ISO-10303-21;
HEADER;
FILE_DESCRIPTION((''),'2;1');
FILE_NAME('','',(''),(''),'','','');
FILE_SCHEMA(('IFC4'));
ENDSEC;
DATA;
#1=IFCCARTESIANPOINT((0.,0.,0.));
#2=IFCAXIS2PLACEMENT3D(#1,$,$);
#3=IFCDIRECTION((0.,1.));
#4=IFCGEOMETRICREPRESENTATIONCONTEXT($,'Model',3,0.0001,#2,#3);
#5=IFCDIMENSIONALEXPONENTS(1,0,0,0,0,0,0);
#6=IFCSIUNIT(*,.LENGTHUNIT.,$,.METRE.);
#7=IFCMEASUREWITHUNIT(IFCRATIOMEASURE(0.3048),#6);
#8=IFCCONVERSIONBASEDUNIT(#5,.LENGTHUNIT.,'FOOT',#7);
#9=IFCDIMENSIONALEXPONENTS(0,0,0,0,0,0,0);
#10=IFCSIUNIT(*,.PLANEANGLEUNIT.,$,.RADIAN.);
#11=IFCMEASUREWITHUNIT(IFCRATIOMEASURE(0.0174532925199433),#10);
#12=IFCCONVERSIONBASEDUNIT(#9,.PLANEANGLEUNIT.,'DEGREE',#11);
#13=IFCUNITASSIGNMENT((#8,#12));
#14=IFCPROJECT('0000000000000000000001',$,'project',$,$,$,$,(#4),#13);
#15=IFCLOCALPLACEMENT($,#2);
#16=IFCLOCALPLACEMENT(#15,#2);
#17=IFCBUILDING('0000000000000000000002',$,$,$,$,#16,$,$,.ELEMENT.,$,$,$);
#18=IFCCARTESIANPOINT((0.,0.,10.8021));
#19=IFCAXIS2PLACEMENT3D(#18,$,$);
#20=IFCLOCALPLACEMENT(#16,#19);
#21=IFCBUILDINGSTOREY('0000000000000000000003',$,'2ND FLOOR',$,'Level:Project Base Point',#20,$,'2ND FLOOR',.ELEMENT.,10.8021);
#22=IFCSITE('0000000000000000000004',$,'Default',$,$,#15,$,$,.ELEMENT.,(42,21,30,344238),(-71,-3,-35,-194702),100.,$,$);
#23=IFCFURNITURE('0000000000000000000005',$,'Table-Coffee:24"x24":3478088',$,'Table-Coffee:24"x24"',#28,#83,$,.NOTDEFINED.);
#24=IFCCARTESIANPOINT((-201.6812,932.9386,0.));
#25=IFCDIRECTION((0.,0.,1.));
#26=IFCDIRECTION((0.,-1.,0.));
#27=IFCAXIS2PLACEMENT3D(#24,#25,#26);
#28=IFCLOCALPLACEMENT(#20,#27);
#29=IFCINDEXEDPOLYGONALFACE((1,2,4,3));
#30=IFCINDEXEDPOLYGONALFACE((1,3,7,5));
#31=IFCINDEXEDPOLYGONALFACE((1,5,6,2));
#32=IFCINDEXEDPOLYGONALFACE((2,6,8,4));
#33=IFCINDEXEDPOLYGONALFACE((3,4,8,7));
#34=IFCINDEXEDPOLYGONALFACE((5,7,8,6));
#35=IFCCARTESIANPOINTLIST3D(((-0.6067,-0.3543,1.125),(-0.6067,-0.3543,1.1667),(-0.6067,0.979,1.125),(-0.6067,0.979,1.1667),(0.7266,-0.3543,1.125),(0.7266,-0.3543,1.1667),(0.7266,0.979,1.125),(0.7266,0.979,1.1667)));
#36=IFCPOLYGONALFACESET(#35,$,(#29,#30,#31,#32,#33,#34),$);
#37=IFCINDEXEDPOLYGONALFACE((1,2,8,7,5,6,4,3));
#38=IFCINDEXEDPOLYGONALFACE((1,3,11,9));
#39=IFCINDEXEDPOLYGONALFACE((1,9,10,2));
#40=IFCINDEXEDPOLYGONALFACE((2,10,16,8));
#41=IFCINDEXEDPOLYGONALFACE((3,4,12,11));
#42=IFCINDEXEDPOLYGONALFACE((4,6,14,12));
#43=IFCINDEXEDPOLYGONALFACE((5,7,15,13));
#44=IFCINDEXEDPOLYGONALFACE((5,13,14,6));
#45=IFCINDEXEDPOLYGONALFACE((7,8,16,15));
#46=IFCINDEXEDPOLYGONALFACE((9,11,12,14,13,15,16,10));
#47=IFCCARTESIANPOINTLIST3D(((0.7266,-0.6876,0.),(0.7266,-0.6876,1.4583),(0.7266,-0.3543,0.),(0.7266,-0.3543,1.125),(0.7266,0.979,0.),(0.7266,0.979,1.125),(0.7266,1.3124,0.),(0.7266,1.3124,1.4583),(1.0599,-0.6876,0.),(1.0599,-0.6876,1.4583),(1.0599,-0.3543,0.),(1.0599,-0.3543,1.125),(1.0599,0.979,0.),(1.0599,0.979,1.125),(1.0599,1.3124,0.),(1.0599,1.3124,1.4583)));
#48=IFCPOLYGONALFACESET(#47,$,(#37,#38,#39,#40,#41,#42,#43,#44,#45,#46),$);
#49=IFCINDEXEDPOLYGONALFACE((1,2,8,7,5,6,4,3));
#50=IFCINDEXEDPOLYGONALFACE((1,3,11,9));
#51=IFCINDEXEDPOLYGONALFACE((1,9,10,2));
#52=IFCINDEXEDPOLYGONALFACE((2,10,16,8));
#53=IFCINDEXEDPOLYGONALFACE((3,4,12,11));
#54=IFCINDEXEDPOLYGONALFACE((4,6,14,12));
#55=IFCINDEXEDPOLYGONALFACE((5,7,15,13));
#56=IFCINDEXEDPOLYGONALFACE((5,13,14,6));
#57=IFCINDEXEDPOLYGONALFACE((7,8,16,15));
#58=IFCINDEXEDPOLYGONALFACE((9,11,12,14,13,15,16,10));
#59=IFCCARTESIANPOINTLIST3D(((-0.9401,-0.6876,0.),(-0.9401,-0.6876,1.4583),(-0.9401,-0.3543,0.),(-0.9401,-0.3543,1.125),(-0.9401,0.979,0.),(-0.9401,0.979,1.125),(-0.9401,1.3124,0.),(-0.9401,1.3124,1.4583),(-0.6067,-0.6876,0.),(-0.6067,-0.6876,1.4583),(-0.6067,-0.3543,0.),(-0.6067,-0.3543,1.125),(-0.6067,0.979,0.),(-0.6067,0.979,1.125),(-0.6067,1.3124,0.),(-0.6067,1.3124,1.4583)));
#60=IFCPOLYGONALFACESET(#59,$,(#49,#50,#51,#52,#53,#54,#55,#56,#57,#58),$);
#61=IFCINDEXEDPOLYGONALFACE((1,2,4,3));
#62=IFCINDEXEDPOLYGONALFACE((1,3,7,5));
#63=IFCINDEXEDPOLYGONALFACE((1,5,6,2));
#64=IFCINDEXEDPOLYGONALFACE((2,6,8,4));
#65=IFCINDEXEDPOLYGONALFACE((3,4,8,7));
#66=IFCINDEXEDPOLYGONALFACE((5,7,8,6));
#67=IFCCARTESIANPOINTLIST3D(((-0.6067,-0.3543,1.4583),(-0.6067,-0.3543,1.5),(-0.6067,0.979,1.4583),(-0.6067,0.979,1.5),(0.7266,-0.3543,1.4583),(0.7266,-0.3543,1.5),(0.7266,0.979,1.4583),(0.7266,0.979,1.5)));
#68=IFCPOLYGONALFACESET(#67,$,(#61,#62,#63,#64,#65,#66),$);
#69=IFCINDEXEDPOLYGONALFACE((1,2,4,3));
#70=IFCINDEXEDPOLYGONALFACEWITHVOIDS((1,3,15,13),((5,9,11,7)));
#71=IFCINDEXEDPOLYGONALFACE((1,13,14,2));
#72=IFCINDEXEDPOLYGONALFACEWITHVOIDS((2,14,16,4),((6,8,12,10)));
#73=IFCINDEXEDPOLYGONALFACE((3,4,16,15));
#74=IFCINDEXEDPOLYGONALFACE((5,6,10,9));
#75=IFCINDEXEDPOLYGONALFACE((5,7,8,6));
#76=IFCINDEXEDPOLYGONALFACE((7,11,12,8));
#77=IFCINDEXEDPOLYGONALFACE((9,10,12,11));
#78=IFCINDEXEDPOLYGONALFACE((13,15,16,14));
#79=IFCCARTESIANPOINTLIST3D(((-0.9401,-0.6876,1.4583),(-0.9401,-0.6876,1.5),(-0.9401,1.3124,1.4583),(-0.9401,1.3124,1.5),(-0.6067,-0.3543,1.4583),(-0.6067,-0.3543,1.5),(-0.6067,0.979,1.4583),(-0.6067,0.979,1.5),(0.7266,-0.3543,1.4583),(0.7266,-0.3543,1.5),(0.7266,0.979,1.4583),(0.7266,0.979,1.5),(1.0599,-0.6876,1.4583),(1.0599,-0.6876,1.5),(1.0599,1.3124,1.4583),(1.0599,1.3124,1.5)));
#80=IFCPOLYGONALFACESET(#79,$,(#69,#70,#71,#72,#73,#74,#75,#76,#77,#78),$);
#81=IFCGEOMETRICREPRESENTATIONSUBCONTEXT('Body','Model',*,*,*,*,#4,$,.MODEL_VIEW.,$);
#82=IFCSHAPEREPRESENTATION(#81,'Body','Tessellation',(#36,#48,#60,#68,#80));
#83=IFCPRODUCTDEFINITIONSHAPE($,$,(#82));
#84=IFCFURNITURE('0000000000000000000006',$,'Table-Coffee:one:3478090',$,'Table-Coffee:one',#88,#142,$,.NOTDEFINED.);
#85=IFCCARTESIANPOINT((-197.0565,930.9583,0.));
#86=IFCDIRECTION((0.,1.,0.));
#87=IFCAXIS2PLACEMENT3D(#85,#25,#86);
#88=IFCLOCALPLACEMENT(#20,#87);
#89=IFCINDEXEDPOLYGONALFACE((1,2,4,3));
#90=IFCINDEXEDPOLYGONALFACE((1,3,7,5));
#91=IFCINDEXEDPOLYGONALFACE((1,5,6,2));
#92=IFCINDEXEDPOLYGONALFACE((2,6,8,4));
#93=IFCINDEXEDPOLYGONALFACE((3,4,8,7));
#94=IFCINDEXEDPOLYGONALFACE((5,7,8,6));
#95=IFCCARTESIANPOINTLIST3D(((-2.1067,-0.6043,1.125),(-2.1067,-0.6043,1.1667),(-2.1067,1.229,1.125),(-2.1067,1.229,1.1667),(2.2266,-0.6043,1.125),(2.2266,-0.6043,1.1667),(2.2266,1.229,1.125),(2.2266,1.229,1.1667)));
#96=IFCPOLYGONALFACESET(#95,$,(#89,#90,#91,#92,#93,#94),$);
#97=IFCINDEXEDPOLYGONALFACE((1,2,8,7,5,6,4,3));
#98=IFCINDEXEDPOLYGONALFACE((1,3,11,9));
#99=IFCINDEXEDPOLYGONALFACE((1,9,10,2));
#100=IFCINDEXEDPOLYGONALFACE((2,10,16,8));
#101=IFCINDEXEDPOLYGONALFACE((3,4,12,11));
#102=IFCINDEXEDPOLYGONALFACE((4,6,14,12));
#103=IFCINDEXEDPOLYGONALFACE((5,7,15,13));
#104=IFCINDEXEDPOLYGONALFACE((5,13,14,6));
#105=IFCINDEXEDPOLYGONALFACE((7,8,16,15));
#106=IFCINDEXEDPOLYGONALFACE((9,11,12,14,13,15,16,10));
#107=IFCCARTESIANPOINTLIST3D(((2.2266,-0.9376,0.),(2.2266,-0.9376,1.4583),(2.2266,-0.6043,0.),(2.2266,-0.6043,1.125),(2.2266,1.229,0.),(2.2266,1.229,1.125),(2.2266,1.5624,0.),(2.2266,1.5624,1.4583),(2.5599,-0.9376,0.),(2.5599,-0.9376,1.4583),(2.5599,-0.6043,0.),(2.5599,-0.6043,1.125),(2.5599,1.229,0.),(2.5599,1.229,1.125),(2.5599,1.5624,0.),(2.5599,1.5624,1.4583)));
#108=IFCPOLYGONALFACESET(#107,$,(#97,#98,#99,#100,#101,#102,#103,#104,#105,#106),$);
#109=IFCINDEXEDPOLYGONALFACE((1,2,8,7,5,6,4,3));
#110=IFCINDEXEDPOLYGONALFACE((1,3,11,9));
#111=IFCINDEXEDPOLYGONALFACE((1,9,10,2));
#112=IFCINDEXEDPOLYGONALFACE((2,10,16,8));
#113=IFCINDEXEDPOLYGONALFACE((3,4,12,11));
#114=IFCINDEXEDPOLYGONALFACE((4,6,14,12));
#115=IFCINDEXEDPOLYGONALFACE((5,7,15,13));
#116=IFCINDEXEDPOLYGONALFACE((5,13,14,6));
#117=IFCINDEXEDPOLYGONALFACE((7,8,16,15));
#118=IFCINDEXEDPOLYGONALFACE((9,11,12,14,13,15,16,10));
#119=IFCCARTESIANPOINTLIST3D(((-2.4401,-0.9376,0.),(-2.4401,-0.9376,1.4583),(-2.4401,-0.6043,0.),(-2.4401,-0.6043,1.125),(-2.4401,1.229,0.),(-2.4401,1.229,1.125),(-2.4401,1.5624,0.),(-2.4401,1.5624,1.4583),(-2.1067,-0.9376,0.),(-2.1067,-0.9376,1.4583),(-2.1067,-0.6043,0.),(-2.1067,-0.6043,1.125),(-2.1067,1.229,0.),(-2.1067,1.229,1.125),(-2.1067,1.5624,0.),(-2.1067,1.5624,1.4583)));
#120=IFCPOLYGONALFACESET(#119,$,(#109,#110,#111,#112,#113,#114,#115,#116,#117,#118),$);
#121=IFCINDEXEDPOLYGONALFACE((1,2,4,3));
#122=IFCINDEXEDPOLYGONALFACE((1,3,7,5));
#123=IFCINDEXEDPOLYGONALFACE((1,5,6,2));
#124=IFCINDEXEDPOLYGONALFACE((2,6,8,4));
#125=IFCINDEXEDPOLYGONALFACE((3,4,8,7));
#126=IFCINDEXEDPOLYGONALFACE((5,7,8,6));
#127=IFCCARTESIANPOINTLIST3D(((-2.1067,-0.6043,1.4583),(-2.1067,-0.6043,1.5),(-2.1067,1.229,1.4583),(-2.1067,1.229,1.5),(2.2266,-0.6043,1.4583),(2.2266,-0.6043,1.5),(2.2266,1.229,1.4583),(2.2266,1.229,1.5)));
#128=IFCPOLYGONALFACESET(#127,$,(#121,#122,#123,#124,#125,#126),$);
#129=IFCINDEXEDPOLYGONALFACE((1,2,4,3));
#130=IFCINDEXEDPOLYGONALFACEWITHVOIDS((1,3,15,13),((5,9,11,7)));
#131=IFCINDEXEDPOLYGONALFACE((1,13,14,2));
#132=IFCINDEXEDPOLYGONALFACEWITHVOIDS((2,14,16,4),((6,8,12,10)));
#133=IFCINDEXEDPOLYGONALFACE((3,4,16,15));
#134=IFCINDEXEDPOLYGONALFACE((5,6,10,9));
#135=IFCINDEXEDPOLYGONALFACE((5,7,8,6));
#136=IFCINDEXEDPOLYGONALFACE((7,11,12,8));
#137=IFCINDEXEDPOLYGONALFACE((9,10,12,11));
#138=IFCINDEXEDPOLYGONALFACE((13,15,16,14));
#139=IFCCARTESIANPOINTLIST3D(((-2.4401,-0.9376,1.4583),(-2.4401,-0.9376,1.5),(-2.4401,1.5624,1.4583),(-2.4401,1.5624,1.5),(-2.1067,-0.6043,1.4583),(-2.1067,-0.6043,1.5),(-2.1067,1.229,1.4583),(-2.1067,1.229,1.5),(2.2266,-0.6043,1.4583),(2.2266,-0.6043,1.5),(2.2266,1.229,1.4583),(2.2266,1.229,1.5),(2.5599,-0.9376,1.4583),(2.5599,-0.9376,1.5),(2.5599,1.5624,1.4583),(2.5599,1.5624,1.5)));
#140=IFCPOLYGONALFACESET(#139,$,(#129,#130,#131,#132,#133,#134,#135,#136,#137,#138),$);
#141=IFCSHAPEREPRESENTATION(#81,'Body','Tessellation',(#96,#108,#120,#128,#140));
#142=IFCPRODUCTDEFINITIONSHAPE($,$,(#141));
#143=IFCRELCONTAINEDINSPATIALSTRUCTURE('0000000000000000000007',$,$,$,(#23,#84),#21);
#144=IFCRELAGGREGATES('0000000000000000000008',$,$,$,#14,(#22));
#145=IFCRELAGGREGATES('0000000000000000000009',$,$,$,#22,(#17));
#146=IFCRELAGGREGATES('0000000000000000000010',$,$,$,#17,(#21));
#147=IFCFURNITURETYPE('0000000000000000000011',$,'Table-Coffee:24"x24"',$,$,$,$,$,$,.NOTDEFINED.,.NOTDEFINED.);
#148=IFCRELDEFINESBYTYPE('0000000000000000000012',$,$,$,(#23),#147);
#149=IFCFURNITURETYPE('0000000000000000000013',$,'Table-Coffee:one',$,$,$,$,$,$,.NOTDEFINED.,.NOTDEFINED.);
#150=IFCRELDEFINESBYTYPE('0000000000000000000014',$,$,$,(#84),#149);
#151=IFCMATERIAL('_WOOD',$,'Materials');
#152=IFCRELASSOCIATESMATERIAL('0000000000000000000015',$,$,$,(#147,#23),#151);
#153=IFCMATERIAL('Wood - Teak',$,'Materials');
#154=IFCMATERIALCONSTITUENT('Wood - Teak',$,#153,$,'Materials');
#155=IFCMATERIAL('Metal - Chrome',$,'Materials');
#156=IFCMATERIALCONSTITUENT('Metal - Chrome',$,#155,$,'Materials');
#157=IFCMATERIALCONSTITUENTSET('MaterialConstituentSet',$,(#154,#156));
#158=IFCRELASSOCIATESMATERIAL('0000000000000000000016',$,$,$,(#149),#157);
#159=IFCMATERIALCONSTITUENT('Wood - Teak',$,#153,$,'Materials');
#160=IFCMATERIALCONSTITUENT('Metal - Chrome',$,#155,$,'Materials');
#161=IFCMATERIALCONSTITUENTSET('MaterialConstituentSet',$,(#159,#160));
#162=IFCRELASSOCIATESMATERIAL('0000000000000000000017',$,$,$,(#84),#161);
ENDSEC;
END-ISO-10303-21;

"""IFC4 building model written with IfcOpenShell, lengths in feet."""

from ifc_helpers import new_model, entity, si_unit, converted_unit, direction, frame, origin, origin_2d_with_axis, place, context, subcontext, project, spatial, polyline, rectangle, outline, extrude, source, transform, mapped, material, constituent, constituent_set, type_object, type_shapes, element, save


model = new_model("IFC4")

# Units and contexts
model_context = context("Model", 3, precision=0.0001, world=origin(), true_north=direction((0.0, 1.0)))
body_context = subcontext(model_context, "Body", "Model", "MODEL_VIEW")
ifc_project = project(units=[converted_unit("LENGTHUNIT", "FOOT", entity("IfcRatioMeasure", 0.3048), si_unit("LENGTHUNIT", "METRE"), dimensions=[1, 0, 0, 0, 0, 0, 0]), converted_unit("PLANEANGLEUNIT", "DEGREE", entity("IfcRatioMeasure", 0.0174532925199433), si_unit("PLANEANGLEUNIT", "RADIAN"), dimensions=[0, 0, 0, 0, 0, 0, 0])], contexts=[model_context])

# Site, building, storey
site_placement = place(None, origin())
site = spatial("IfcSite", under=ifc_project, at=site_placement, Name="Default", CompositionType="ELEMENT", RefLatitude=(42, 21, 30, 344238), RefLongitude=(-71, -3, -35, -194702), RefElevation=100.0)
building_placement = place(site_placement, origin())
building = spatial("IfcBuilding", under=site, at=building_placement, CompositionType="ELEMENT")
storey_placement = place(building_placement, frame((0.0, 0.0, 10.8021)))
storey = spatial("IfcBuildingStorey", under=building, at=storey_placement, Name="2ND FLOOR", ObjectType="Level:Project Base Point", LongName="2ND FLOOR", CompositionType="ELEMENT", Elevation=10.8021)

# Furniture
ifc_material_1 = material(Name="_WOOD", Category="Materials")
furniture_type_1 = type_object("IfcFurnitureType", Name="Table-Coffee:24\"x24\"", AssemblyPlace="NOTDEFINED", PredefinedType="NOTDEFINED", material=ifc_material_1)
shared_shape_1 = source(origin(), body_context, "Body", "SweptSolid", [
    extrude(rectangle(XDim=1.3333, YDim=1.3333, at=origin_2d_with_axis()), frame((0.0599, 0.3124, 1.125), z_axis=(0.0, 0.0, 1.0), x_axis=(-1.0, 0.0, 0.0)), (0.0, 0.0, 1.0), 0.0417),
    extrude(outline(polyline([(-0.6458, -1.0), (0.8125, -1.0), (0.8125, 1.0), (-0.6458, 1.0), (-0.6458, 0.6667), (0.4792, 0.6667), (0.4792, -0.6667), (-0.6458, -0.6667), (-0.6458, -1.0)])), frame((0.7266, 0.3124, 0.6458), z_axis=(1.0, 0.0, 0.0), x_axis=(0.0, 0.0, 1.0)), (0.0, 0.0, 1.0), 0.3333),
    extrude(outline(polyline([(-1.0, -0.8125), (1.0, -0.8125), (1.0, 0.6458), (0.6667, 0.6458), (0.6667, -0.4792), (-0.6667, -0.4792), (-0.6667, 0.6458), (-1.0, 0.6458), (-1.0, -0.8125)])), frame((-0.9401, 0.3124, 0.6458), z_axis=(1.0, 0.0, 0.0), x_axis=(0.0, -1.0, 0.0)), (0.0, 0.0, 1.0), 0.3333),
    extrude(rectangle(XDim=1.3333, YDim=1.3333, at=origin_2d_with_axis()), frame((0.0599, 0.3124, 1.4583), z_axis=(0.0, 0.0, 1.0), x_axis=(-1.0, 0.0, 0.0)), (0.0, 0.0, 1.0), 0.0417),
    extrude(outline(polyline([(-1.0, -1.0), (1.0, -1.0), (1.0, 1.0), (-1.0, 1.0), (-1.0, -1.0)]), holes=[polyline([(-0.6667, -0.6667), (-0.6667, 0.6667), (0.6667, 0.6667), (0.6667, -0.6667), (-0.6667, -0.6667)])]), frame((0.0599, 0.3124, 1.4583), z_axis=(0.0, 0.0, 1.0), x_axis=(-1.0, 0.0, 0.0)), (0.0, 0.0, 1.0), 0.0417),
])
type_shapes(furniture_type_1, [shared_shape_1])
furniture_1_placement = place(storey_placement, frame((-201.6812, 932.9386, 0.0), z_axis=(0.0, 0.0, 1.0), x_axis=(0.0, -1.0, 0.0)))
element("IfcFurniture", 1, at=furniture_1_placement, inside=storey, type_object=furniture_type_1, material=ifc_material_1, Name="Table-Coffee:24\"x24\":3478088", ObjectType="Table-Coffee:24\"x24\"", PredefinedType="NOTDEFINED", context=body_context, shape_type="MappedRepresentation", body=[
    mapped(shared_shape_1, transform((0.0, 0.0, 0.0), scale=1.0)),
])
ifc_material_2 = material(Name="Wood - Teak", Category="Materials")
ifc_constituent_1 = constituent(ifc_material_2, Name="Wood - Teak", Category="Materials")
ifc_material_3 = material(Name="Metal - Chrome", Category="Materials")
ifc_constituent_2 = constituent(ifc_material_3, Name="Metal - Chrome", Category="Materials")
ifc_constituent_set_1 = constituent_set(constituents=[ifc_constituent_1, ifc_constituent_2], Name="MaterialConstituentSet")
ifc_constituent_3 = constituent(ifc_material_2, Name="Wood - Teak", Category="Materials")
ifc_constituent_4 = constituent(ifc_material_3, Name="Metal - Chrome", Category="Materials")
ifc_constituent_set_2 = constituent_set(constituents=[ifc_constituent_3, ifc_constituent_4], Name="MaterialConstituentSet")
furniture_type_2 = type_object("IfcFurnitureType", Name="Table-Coffee:one", AssemblyPlace="NOTDEFINED", PredefinedType="NOTDEFINED", material=ifc_constituent_set_2)
shared_shape_2 = source(origin(), body_context, "Body", "SweptSolid", [
    extrude(rectangle(XDim=4.3333, YDim=1.8333, at=origin_2d_with_axis()), frame((0.0599, 0.3124, 1.125), z_axis=(0.0, 0.0, 1.0), x_axis=(-1.0, 0.0, 0.0)), (0.0, 0.0, 1.0), 0.0417),
    extrude(outline(polyline([(-0.6458, -1.25), (0.8125, -1.25), (0.8125, 1.25), (-0.6458, 1.25), (-0.6458, 0.9167), (0.4792, 0.9167), (0.4792, -0.9167), (-0.6458, -0.9167), (-0.6458, -1.25)])), frame((2.2266, 0.3124, 0.6458), z_axis=(1.0, 0.0, 0.0), x_axis=(0.0, 0.0, 1.0)), (0.0, 0.0, 1.0), 0.3333),
    extrude(outline(polyline([(-1.25, -0.8125), (1.25, -0.8125), (1.25, 0.6458), (0.9167, 0.6458), (0.9167, -0.4792), (-0.9167, -0.4792), (-0.9167, 0.6458), (-1.25, 0.6458), (-1.25, -0.8125)])), frame((-2.4401, 0.3124, 0.6458), z_axis=(1.0, 0.0, 0.0), x_axis=(0.0, -1.0, 0.0)), (0.0, 0.0, 1.0), 0.3333),
    extrude(rectangle(XDim=4.3333, YDim=1.8333, at=origin_2d_with_axis()), frame((0.0599, 0.3124, 1.4583), z_axis=(0.0, 0.0, 1.0), x_axis=(-1.0, 0.0, 0.0)), (0.0, 0.0, 1.0), 0.0417),
    extrude(outline(polyline([(-2.5, -1.25), (2.5, -1.25), (2.5, 1.25), (-2.5, 1.25), (-2.5, -1.25)]), holes=[polyline([(-2.1667, -0.9167), (-2.1667, 0.9167), (2.1667, 0.9167), (2.1667, -0.9167), (-2.1667, -0.9167)])]), frame((0.0599, 0.3124, 1.4583), z_axis=(0.0, 0.0, 1.0), x_axis=(-1.0, 0.0, 0.0)), (0.0, 0.0, 1.0), 0.0417),
])
type_shapes(furniture_type_2, [shared_shape_2])
furniture_2_placement = place(storey_placement, frame((-197.0565, 930.9583, 0.0), z_axis=(0.0, 0.0, 1.0), x_axis=(0.0, 1.0, 0.0)))
element("IfcFurniture", 2, at=furniture_2_placement, inside=storey, type_object=furniture_type_2, material=ifc_constituent_set_1, Name="Table-Coffee:one:3478090", ObjectType="Table-Coffee:one", PredefinedType="NOTDEFINED", context=body_context, shape_type="MappedRepresentation", body=[
    mapped(shared_shape_2, transform((0.0, 0.0, 0.0), scale=1.0)),
])

save(model, "model.ifc")
